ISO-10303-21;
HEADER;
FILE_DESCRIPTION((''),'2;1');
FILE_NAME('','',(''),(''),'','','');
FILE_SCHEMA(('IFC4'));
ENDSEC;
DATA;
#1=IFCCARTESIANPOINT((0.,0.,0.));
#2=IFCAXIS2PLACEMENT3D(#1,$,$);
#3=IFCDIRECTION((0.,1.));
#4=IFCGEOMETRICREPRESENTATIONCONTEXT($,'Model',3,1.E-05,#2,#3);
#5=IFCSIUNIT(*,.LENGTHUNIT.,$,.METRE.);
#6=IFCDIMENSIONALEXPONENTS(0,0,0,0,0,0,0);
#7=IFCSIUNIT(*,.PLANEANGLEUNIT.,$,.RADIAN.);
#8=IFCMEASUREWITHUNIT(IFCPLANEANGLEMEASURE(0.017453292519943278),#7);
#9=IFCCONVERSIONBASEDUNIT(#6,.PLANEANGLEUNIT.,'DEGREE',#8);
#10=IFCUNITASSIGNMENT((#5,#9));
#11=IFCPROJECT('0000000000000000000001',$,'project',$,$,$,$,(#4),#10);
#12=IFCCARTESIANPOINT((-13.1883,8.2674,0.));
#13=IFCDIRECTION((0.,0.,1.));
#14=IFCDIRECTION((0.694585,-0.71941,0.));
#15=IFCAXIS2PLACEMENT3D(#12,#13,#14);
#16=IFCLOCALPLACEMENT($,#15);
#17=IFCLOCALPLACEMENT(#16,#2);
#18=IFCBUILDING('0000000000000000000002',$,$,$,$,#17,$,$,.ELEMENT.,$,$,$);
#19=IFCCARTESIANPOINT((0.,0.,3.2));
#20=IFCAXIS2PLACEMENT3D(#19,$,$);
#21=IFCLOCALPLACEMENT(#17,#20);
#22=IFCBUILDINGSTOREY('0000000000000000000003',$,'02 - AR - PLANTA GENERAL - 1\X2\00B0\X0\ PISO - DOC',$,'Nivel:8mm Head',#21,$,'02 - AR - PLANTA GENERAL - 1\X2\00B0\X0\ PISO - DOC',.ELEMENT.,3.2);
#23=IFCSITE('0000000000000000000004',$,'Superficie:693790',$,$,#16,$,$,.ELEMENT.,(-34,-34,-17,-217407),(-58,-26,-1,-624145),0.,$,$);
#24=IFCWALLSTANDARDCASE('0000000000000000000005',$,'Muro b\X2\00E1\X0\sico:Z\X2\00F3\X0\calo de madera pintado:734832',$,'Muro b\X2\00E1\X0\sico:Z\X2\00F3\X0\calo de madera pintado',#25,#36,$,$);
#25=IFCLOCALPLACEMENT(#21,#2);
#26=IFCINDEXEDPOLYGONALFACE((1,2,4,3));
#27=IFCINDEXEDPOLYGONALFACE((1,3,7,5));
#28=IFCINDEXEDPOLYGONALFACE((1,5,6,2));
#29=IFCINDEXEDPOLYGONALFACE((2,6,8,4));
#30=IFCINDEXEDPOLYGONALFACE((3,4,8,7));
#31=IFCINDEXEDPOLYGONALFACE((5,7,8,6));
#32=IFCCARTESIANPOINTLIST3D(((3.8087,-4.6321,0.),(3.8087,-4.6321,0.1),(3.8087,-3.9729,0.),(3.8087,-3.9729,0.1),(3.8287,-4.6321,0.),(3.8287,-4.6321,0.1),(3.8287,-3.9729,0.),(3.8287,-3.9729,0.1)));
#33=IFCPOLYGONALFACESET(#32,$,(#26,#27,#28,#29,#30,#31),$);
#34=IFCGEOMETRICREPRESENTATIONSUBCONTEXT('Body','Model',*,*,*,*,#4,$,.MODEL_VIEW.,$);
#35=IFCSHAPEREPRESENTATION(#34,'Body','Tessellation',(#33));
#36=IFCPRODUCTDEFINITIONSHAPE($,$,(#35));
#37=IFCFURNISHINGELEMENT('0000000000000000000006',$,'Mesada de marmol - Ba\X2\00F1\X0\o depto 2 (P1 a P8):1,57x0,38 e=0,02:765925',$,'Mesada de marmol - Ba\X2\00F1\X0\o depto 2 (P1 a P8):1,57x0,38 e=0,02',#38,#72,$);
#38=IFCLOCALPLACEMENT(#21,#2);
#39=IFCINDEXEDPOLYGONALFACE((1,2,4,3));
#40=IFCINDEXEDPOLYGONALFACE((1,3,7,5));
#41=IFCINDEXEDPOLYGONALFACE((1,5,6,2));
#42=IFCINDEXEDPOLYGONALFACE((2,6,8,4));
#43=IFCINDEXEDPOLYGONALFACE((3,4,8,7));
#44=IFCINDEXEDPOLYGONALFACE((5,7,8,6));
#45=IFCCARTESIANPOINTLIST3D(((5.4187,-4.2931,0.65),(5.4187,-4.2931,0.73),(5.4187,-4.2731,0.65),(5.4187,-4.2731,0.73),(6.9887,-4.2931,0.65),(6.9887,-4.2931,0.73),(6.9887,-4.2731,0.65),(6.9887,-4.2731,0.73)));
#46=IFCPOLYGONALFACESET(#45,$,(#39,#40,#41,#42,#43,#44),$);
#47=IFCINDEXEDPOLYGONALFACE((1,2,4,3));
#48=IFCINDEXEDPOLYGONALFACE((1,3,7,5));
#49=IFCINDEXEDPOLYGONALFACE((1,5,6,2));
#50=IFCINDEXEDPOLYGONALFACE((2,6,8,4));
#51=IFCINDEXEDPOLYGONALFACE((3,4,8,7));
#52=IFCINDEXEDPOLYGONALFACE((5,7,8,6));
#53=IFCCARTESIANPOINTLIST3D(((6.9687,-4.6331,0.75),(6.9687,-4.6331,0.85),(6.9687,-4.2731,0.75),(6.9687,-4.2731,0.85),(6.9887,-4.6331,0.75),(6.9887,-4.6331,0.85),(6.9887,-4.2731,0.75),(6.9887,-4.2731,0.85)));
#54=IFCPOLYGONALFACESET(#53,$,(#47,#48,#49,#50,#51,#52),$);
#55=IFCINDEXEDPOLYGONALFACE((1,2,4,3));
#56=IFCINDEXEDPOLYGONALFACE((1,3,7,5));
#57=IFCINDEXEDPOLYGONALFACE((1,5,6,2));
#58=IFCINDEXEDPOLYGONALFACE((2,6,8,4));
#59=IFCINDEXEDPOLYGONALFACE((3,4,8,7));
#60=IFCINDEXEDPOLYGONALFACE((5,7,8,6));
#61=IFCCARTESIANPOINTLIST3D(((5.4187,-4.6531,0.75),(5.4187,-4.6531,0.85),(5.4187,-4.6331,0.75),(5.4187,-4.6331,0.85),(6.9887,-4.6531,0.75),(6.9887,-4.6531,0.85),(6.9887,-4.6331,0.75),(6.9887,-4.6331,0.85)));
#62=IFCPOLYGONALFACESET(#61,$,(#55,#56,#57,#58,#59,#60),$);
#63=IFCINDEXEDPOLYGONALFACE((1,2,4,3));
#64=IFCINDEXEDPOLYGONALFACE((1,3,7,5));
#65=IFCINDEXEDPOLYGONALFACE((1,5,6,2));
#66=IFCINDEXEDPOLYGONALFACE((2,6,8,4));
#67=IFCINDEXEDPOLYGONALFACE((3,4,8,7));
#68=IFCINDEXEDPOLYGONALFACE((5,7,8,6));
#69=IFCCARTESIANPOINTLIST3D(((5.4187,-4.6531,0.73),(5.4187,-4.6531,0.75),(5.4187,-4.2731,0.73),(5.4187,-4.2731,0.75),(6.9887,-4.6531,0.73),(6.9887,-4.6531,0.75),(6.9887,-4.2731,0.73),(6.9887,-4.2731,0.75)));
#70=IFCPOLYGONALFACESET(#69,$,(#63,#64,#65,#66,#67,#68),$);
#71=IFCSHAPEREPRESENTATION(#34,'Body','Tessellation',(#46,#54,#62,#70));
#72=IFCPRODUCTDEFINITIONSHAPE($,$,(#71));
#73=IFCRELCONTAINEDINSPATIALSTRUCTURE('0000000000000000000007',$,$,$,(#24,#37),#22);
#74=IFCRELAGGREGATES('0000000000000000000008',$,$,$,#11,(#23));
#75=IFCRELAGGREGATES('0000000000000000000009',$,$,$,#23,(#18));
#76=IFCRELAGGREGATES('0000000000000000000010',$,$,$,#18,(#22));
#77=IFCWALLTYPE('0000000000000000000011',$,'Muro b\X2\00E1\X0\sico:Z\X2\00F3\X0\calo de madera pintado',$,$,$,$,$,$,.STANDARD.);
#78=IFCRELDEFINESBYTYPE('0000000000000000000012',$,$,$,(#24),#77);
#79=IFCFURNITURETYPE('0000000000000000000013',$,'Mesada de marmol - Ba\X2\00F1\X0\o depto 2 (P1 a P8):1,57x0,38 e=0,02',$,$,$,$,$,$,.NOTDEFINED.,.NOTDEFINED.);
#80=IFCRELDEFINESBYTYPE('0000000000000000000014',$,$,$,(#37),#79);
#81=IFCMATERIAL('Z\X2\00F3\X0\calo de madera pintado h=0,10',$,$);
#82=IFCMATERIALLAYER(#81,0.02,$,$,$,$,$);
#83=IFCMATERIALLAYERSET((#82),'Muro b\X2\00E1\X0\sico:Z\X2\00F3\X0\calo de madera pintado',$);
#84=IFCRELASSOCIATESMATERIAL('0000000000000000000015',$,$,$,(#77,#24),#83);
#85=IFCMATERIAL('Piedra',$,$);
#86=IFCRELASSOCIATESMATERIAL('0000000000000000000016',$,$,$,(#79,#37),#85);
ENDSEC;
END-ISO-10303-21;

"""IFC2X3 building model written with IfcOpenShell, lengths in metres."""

from ifc_helpers import new_model, entity, si_unit, converted_unit, direction, frame, frame_2d, origin, origin_2d_with_axis, place, context, subcontext, project, spatial, rectangle, extrude, source, transform, mapped, material, layer, layer_set, layer_usage, type_object, type_shapes, element, save


model = new_model("IFC2X3")

# Units and contexts
model_context = context("Model", 3, precision=1e-05, world=origin(), true_north=direction((0.0, 1.0)))
body_context = subcontext(model_context, "Body", "Model", "MODEL_VIEW")
ifc_project = project(units=[si_unit("LENGTHUNIT", "METRE"), converted_unit("PLANEANGLEUNIT", "DEGREE", entity("IfcPlaneAngleMeasure", 0.017453292519943278), si_unit("PLANEANGLEUNIT", "RADIAN"), dimensions=[0, 0, 0, 0, 0, 0, 0])], contexts=[model_context])

# Site, building, storey
site_placement = place(None, frame((-13.1883, 8.2674, 0.0), z_axis=(0.0, 0.0, 1.0), x_axis=(0.694585, -0.71941, 0.0)))
site = spatial("IfcSite", under=ifc_project, at=site_placement, Name="Superficie:693790", CompositionType="ELEMENT", RefLatitude=(-34, -34, -17, -217407), RefLongitude=(-58, -26, -1, -624145), RefElevation=0.0)
building_placement = place(site_placement, origin())
building = spatial("IfcBuilding", under=site, at=building_placement, CompositionType="ELEMENT")
storey_placement = place(building_placement, frame((0.0, 0.0, 3.2)))
storey = spatial("IfcBuildingStorey", under=building, at=storey_placement, Name="02 - AR - PLANTA GENERAL - 1° PISO - DOC", ObjectType="Nivel:8mm Head", LongName="02 - AR - PLANTA GENERAL - 1° PISO - DOC", CompositionType="ELEMENT", Elevation=3.2)

# Wall
ifc_material_1 = material(Name="Zócalo de madera pintado h=0,10")
ifc_layer_1 = layer(ifc_material_1, 0.02)
ifc_layer_set_1 = layer_set([ifc_layer_1], Name="Muro básico:Zócalo de madera pintado")
wall_type_1 = type_object("IfcWallType", Name="Muro básico:Zócalo de madera pintado", PredefinedType="STANDARD", material=ifc_layer_set_1)
ifc_layer_usage_1 = layer_usage(ifc_layer_set_1, "AXIS2", "NEGATIVE", 0.01)
wall_1_placement = place(storey_placement, frame((3.8187, -4.6321, 0.0), z_axis=(0.0, 0.0, 1.0), x_axis=(0.0, 1.0, 0.0)))
element("IfcWallStandardCase", 1, at=wall_1_placement, inside=storey, type_object=wall_type_1, material=ifc_layer_usage_1, Name="Muro básico:Zócalo de madera pintado:734832", ObjectType="Muro básico:Zócalo de madera pintado", context=body_context, shape_type="SweptSolid", body=[
    extrude(rectangle(XDim=0.6592, YDim=0.02, at=frame_2d((0.3296, 0.0), x_axis=(-1.0, 0.0))), origin(), (0.0, 0.0, 1.0), 0.1),
])

# Furnishing element
ifc_material_2 = material(Name="Piedra")
furniture_type = type_object("IfcFurnitureType", Name="Mesada de marmol - Baño depto 2 (P1 a P8):1,57x0,38 e=0,02", AssemblyPlace="NOTDEFINED", material=ifc_material_2)
shared_shape_1 = source(origin(), body_context, "Body", "SweptSolid", [
    extrude(rectangle(XDim=0.02, YDim=1.57, at=frame_2d((0.0, 0.0), x_axis=(1.0, 0.0))), frame((-0.4155, -0.37, 0.65), z_axis=(0.0, 0.0, 1.0), x_axis=(0.0, 1.0, 0.0)), (0.0, 0.0, 1.0), 0.08),
    extrude(rectangle(XDim=0.02, YDim=0.36, at=frame_2d((0.0, 0.0), x_axis=(1.0, 0.0))), frame((-1.1905, -0.2, 0.75), z_axis=(0.0, 0.0, 1.0), x_axis=(-1.0, 0.0, 0.0)), (0.0, 0.0, 1.0), 0.1),
    extrude(rectangle(XDim=0.02, YDim=1.57, at=origin_2d_with_axis()), frame((-0.4155, -0.01, 0.75), z_axis=(0.0, 0.0, 1.0), x_axis=(0.0, -1.0, 0.0)), (0.0, 0.0, 1.0), 0.1),
    extrude(rectangle(XDim=1.57, YDim=0.38, at=origin_2d_with_axis()), frame((-0.4155, -0.19, 0.73), z_axis=(0.0, 0.0, 1.0), x_axis=(-1.0, 0.0, 0.0)), (0.0, 0.0, 1.0), 0.02),
])
type_shapes(furniture_type, [shared_shape_1])
furnishing_placement = place(storey_placement, frame((5.7882, -4.6531, 0.0), z_axis=(0.0, 0.0, 1.0), x_axis=(-1.0, 0.0, 0.0)))
element("IfcFurnishingElement", 2, at=furnishing_placement, inside=storey, type_object=furniture_type, material=ifc_material_2, Name="Mesada de marmol - Baño depto 2 (P1 a P8):1,57x0,38 e=0,02:765925", ObjectType="Mesada de marmol - Baño depto 2 (P1 a P8):1,57x0,38 e=0,02", context=body_context, shape_type="MappedRepresentation", body=[
    mapped(shared_shape_1, transform((0.0, 0.0, 0.0), scale=1.0)),
])

save(model, "model.ifc")
